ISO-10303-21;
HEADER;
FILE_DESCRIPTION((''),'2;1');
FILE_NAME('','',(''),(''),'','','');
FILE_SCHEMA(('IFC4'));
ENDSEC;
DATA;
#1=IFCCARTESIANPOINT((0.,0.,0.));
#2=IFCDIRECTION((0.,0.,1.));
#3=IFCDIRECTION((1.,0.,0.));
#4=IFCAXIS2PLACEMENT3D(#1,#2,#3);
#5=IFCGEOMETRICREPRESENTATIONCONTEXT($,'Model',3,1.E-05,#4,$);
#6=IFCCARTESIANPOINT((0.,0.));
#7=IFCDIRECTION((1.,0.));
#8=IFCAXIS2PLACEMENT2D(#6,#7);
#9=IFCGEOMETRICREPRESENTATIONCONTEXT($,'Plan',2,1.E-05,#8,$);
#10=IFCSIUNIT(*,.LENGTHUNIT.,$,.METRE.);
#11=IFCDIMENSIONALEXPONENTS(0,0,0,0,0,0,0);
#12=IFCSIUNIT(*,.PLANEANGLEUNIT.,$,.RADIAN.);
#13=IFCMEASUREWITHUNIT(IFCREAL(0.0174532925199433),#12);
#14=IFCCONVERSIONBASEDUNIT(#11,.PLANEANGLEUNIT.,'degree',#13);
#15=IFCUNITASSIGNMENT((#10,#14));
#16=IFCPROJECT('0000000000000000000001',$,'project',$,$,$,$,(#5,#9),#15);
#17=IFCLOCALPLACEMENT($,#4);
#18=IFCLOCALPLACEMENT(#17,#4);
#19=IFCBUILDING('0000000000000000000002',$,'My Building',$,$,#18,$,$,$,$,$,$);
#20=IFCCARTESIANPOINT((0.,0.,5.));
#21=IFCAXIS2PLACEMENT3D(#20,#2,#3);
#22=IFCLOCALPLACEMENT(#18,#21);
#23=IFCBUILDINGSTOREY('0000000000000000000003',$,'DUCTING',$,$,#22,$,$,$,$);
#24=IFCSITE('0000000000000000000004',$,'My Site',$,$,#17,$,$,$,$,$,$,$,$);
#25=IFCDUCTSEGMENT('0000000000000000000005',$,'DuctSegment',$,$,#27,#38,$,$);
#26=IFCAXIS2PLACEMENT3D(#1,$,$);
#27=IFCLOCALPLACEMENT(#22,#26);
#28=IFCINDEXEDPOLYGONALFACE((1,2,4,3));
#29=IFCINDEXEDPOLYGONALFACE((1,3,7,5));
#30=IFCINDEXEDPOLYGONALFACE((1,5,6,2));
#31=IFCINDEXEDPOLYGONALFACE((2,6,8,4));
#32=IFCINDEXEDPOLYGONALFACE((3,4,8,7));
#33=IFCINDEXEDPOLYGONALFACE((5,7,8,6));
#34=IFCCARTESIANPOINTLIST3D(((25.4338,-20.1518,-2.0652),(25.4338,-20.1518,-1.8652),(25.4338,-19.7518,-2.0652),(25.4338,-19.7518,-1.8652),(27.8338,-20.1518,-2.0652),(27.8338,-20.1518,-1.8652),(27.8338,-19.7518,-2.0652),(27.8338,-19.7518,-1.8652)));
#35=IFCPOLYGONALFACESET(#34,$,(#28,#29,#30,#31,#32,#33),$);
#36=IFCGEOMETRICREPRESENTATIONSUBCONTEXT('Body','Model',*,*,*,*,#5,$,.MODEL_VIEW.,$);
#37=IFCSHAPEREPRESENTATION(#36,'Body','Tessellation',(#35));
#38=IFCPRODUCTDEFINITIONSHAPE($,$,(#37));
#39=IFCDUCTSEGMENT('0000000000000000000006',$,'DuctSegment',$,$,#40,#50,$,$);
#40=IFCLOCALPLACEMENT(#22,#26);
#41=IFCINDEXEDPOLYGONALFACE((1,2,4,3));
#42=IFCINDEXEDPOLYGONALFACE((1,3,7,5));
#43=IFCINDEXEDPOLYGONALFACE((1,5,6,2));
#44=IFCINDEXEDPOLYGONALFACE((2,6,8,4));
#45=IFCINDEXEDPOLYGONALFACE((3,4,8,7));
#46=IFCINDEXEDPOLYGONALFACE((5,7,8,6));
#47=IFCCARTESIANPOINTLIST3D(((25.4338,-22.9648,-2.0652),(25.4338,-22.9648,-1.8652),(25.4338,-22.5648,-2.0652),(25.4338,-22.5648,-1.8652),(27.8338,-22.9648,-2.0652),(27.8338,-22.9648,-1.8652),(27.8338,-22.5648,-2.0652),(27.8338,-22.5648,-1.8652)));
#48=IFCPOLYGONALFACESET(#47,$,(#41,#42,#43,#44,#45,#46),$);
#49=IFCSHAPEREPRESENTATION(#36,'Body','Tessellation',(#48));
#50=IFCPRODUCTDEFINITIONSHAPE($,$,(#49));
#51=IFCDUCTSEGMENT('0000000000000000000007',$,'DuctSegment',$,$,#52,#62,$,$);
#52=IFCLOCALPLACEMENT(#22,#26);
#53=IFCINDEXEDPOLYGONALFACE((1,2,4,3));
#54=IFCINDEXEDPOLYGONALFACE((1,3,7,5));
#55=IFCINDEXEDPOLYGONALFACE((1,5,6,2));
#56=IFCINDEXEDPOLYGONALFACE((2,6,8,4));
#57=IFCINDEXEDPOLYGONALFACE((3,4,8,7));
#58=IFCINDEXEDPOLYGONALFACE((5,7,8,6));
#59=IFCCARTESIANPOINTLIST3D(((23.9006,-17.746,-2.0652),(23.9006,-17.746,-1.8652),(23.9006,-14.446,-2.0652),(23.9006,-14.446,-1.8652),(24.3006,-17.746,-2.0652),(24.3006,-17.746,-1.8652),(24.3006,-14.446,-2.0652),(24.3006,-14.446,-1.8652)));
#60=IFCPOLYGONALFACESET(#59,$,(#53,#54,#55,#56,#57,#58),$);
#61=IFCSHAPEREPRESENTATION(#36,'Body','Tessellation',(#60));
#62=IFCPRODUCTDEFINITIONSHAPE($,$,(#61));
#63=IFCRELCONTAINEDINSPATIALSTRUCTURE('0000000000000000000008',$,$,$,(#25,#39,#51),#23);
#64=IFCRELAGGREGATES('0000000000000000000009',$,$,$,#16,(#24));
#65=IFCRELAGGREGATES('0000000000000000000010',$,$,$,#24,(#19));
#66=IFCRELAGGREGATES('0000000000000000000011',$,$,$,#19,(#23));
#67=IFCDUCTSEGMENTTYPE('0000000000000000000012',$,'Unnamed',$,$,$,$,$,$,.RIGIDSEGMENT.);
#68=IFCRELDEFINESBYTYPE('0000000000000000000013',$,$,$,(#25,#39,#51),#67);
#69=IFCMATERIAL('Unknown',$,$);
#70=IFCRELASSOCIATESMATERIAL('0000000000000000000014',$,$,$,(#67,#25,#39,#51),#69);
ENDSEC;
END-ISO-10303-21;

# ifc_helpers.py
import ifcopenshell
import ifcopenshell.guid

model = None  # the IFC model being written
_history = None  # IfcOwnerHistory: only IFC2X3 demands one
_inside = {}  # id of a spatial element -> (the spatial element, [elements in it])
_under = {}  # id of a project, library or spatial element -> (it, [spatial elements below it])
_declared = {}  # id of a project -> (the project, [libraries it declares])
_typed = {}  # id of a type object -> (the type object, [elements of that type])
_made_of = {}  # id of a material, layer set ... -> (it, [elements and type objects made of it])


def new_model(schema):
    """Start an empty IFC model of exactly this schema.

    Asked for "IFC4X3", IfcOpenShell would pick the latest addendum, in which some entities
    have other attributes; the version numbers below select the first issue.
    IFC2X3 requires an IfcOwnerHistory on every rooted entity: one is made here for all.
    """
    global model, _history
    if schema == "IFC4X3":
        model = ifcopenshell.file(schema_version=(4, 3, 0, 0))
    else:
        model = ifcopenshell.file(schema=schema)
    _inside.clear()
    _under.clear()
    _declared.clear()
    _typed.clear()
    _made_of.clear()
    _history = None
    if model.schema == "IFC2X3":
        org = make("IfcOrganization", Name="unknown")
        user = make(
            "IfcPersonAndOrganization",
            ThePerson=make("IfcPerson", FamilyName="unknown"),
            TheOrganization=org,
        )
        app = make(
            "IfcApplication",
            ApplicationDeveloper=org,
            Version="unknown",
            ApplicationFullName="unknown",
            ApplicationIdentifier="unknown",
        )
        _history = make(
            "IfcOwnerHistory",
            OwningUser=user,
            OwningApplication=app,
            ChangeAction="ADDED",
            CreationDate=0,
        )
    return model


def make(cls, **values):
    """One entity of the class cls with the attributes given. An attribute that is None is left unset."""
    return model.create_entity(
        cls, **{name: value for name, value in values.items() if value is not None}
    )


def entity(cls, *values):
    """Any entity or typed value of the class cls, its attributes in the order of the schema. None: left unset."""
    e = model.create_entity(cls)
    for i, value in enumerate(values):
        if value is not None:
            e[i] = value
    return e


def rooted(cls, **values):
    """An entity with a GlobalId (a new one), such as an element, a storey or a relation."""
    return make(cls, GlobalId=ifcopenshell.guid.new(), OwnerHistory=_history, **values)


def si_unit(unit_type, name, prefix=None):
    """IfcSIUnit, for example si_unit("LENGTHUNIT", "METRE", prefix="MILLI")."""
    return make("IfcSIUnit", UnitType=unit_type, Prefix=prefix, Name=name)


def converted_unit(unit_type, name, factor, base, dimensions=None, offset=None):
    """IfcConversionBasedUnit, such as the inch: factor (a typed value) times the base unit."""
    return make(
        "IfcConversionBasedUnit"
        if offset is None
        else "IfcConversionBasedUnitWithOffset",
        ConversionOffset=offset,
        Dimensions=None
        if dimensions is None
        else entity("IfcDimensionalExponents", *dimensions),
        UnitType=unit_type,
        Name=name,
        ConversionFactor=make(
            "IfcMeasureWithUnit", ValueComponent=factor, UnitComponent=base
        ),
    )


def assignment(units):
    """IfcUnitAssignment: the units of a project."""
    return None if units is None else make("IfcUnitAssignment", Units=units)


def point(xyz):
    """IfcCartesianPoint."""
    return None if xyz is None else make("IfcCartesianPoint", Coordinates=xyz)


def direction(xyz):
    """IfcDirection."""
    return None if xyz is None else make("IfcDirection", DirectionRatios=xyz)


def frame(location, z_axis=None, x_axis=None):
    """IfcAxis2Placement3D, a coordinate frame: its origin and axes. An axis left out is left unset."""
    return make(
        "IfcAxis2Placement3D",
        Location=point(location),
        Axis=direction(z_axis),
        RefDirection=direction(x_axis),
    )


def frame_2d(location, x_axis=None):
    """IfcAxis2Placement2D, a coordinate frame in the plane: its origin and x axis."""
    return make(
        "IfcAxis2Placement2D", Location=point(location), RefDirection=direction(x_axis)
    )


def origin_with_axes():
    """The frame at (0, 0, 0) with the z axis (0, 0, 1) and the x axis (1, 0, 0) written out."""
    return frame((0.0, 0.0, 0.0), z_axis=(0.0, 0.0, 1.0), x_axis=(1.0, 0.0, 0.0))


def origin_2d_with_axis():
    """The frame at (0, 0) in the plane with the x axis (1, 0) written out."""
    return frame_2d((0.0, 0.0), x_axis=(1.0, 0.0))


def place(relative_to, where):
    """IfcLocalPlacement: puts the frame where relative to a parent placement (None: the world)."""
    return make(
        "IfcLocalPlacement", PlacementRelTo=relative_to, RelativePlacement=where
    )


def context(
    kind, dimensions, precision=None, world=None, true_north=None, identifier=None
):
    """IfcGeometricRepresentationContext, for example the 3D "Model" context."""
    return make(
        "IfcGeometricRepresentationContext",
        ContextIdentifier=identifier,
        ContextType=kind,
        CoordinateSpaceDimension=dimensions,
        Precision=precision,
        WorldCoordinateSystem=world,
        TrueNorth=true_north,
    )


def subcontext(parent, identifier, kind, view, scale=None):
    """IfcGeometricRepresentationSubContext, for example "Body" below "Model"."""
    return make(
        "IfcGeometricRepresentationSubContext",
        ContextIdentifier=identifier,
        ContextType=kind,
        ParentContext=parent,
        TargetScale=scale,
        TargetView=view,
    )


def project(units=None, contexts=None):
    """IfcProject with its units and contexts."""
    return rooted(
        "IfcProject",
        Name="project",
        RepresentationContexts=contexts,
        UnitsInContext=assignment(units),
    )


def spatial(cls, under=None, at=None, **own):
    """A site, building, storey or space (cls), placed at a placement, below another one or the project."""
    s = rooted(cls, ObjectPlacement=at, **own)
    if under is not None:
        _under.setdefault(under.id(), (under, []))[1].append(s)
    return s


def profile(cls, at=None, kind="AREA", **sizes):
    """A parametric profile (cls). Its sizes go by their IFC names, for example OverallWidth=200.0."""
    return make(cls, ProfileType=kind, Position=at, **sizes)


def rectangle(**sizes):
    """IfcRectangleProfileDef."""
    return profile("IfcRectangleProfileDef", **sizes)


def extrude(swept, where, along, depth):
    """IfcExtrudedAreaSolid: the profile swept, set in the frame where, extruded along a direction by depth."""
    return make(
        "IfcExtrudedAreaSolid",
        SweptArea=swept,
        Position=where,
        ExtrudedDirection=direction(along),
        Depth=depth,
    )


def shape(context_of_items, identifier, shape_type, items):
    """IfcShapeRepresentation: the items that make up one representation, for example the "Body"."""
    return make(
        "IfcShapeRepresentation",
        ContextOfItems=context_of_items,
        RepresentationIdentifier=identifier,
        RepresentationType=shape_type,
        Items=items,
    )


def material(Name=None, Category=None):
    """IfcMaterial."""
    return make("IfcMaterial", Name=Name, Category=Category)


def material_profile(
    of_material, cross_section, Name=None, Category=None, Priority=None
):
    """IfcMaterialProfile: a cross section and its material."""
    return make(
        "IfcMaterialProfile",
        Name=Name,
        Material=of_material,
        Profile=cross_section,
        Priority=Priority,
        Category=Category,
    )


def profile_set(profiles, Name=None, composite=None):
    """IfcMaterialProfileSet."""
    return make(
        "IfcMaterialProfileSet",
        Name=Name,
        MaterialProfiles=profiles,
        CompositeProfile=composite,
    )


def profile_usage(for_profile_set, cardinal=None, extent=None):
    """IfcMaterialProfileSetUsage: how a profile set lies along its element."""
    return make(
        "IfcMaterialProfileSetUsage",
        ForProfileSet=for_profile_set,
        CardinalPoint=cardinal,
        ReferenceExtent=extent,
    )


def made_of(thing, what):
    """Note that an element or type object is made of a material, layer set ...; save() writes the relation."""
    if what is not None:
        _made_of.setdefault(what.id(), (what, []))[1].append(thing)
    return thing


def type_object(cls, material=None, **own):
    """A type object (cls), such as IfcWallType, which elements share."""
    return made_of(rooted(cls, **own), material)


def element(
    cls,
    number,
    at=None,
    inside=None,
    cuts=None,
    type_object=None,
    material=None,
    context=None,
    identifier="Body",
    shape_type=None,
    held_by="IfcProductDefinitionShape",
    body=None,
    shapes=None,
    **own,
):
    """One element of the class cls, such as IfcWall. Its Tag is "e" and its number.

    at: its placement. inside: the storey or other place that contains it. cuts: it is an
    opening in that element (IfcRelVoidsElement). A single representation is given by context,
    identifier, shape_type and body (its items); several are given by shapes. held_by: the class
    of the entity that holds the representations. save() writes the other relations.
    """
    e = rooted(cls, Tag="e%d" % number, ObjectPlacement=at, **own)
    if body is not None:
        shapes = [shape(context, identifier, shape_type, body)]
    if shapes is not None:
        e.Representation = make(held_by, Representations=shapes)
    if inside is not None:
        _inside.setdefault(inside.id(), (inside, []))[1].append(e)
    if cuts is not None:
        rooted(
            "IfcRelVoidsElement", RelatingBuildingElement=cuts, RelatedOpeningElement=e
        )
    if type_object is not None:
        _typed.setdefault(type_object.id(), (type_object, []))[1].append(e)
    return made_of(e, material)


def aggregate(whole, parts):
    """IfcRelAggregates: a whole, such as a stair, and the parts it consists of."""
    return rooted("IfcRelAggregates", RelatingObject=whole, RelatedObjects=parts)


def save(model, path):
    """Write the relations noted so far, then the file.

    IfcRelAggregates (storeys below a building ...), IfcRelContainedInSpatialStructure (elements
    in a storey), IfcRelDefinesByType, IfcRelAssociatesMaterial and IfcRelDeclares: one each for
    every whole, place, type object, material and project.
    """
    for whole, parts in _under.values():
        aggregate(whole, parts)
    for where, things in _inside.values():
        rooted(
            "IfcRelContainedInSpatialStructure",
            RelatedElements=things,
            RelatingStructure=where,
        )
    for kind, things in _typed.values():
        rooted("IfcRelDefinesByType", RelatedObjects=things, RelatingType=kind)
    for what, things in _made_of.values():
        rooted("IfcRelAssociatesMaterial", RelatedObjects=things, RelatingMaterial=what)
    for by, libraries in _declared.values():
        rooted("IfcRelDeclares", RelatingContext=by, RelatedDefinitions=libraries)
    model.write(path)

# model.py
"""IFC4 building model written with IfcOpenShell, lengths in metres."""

from ifc_helpers import new_model, entity, si_unit, converted_unit, frame, origin_with_axes, origin_2d_with_axis, place, context, subcontext, project, spatial, rectangle, extrude, material, material_profile, profile_set, profile_usage, type_object, element, save


model = new_model("IFC4")

# Units and contexts
model_context = context("Model", 3, precision=1e-05, world=origin_with_axes())
plan_context = context("Plan", 2, precision=1e-05, world=origin_2d_with_axis())
body_context = subcontext(model_context, "Body", "Model", "MODEL_VIEW")
ifc_project = project(units=[si_unit("LENGTHUNIT", "METRE"), converted_unit("PLANEANGLEUNIT", "degree", entity("IfcReal", 0.0174532925199433), si_unit("PLANEANGLEUNIT", "RADIAN"), dimensions=[0, 0, 0, 0, 0, 0, 0])], contexts=[model_context, plan_context])

# Site, building, storey
site_placement = place(None, origin_with_axes())
site = spatial("IfcSite", under=ifc_project, at=site_placement, Name="My Site")
building_placement = place(site_placement, origin_with_axes())
building = spatial("IfcBuilding", under=site, at=building_placement, Name="My Building")
storey_placement = place(building_placement, frame((0.0, 0.0, 5.0), z_axis=(0.0, 0.0, 1.0), x_axis=(1.0, 0.0, 0.0)))
storey = spatial("IfcBuildingStorey", under=building, at=storey_placement, Name="DUCTING")

# Duct segments
ifc_material = material(Name="Unknown")
ifc_material_profile = material_profile(ifc_material, rectangle(XDim=0.4, YDim=0.2))
ifc_profile_set = profile_set([ifc_material_profile])
duct_segment_type = type_object("IfcDuctSegmentType", Name="Unnamed", PredefinedType="RIGIDSEGMENT", material=ifc_profile_set)
ifc_profile_usage_1 = profile_usage(ifc_profile_set, cardinal=5)
duct_segment_1_placement = place(storey_placement, frame((25.4338, -19.9518, -1.9652), z_axis=(1.0, -0.000001, 0.000001), x_axis=(0.000001, 1.0, 0.0)))
element("IfcDuctSegment", 1, at=duct_segment_1_placement, inside=storey, type_object=duct_segment_type, material=ifc_profile_usage_1, Name="DuctSegment", context=body_context, shape_type="SweptSolid", body=[
    extrude(rectangle(XDim=0.4, YDim=0.2), origin_with_axes(), (0.0, 0.0, 1.0), 2.4),
])
ifc_profile_usage_2 = profile_usage(ifc_profile_set, cardinal=5)
duct_segment_2_placement = place(storey_placement, frame((25.4338, -22.7648, -1.9652), z_axis=(1.0, -0.000001, 0.000001), x_axis=(0.000001, 1.0, 0.0)))
element("IfcDuctSegment", 2, at=duct_segment_2_placement, inside=storey, type_object=duct_segment_type, material=ifc_profile_usage_2, Name="DuctSegment", context=body_context, shape_type="SweptSolid", body=[
    extrude(rectangle(XDim=0.4, YDim=0.2), origin_with_axes(), (0.0, 0.0, 1.0), 2.4),
])
ifc_profile_usage_3 = profile_usage(ifc_profile_set, cardinal=5)
duct_segment_3_placement = place(storey_placement, frame((24.1006, -14.446, -1.9652), z_axis=(0.0, -1.0, 0.000001), x_axis=(1.0, 0.0, 0.0)))
element("IfcDuctSegment", 3, at=duct_segment_3_placement, inside=storey, type_object=duct_segment_type, material=ifc_profile_usage_3, Name="DuctSegment", context=body_context, shape_type="SweptSolid", body=[
    extrude(rectangle(XDim=0.4, YDim=0.2), origin_with_axes(), (0.0, 0.0, 1.0), 3.3),
])

save(model, "model.ifc")
